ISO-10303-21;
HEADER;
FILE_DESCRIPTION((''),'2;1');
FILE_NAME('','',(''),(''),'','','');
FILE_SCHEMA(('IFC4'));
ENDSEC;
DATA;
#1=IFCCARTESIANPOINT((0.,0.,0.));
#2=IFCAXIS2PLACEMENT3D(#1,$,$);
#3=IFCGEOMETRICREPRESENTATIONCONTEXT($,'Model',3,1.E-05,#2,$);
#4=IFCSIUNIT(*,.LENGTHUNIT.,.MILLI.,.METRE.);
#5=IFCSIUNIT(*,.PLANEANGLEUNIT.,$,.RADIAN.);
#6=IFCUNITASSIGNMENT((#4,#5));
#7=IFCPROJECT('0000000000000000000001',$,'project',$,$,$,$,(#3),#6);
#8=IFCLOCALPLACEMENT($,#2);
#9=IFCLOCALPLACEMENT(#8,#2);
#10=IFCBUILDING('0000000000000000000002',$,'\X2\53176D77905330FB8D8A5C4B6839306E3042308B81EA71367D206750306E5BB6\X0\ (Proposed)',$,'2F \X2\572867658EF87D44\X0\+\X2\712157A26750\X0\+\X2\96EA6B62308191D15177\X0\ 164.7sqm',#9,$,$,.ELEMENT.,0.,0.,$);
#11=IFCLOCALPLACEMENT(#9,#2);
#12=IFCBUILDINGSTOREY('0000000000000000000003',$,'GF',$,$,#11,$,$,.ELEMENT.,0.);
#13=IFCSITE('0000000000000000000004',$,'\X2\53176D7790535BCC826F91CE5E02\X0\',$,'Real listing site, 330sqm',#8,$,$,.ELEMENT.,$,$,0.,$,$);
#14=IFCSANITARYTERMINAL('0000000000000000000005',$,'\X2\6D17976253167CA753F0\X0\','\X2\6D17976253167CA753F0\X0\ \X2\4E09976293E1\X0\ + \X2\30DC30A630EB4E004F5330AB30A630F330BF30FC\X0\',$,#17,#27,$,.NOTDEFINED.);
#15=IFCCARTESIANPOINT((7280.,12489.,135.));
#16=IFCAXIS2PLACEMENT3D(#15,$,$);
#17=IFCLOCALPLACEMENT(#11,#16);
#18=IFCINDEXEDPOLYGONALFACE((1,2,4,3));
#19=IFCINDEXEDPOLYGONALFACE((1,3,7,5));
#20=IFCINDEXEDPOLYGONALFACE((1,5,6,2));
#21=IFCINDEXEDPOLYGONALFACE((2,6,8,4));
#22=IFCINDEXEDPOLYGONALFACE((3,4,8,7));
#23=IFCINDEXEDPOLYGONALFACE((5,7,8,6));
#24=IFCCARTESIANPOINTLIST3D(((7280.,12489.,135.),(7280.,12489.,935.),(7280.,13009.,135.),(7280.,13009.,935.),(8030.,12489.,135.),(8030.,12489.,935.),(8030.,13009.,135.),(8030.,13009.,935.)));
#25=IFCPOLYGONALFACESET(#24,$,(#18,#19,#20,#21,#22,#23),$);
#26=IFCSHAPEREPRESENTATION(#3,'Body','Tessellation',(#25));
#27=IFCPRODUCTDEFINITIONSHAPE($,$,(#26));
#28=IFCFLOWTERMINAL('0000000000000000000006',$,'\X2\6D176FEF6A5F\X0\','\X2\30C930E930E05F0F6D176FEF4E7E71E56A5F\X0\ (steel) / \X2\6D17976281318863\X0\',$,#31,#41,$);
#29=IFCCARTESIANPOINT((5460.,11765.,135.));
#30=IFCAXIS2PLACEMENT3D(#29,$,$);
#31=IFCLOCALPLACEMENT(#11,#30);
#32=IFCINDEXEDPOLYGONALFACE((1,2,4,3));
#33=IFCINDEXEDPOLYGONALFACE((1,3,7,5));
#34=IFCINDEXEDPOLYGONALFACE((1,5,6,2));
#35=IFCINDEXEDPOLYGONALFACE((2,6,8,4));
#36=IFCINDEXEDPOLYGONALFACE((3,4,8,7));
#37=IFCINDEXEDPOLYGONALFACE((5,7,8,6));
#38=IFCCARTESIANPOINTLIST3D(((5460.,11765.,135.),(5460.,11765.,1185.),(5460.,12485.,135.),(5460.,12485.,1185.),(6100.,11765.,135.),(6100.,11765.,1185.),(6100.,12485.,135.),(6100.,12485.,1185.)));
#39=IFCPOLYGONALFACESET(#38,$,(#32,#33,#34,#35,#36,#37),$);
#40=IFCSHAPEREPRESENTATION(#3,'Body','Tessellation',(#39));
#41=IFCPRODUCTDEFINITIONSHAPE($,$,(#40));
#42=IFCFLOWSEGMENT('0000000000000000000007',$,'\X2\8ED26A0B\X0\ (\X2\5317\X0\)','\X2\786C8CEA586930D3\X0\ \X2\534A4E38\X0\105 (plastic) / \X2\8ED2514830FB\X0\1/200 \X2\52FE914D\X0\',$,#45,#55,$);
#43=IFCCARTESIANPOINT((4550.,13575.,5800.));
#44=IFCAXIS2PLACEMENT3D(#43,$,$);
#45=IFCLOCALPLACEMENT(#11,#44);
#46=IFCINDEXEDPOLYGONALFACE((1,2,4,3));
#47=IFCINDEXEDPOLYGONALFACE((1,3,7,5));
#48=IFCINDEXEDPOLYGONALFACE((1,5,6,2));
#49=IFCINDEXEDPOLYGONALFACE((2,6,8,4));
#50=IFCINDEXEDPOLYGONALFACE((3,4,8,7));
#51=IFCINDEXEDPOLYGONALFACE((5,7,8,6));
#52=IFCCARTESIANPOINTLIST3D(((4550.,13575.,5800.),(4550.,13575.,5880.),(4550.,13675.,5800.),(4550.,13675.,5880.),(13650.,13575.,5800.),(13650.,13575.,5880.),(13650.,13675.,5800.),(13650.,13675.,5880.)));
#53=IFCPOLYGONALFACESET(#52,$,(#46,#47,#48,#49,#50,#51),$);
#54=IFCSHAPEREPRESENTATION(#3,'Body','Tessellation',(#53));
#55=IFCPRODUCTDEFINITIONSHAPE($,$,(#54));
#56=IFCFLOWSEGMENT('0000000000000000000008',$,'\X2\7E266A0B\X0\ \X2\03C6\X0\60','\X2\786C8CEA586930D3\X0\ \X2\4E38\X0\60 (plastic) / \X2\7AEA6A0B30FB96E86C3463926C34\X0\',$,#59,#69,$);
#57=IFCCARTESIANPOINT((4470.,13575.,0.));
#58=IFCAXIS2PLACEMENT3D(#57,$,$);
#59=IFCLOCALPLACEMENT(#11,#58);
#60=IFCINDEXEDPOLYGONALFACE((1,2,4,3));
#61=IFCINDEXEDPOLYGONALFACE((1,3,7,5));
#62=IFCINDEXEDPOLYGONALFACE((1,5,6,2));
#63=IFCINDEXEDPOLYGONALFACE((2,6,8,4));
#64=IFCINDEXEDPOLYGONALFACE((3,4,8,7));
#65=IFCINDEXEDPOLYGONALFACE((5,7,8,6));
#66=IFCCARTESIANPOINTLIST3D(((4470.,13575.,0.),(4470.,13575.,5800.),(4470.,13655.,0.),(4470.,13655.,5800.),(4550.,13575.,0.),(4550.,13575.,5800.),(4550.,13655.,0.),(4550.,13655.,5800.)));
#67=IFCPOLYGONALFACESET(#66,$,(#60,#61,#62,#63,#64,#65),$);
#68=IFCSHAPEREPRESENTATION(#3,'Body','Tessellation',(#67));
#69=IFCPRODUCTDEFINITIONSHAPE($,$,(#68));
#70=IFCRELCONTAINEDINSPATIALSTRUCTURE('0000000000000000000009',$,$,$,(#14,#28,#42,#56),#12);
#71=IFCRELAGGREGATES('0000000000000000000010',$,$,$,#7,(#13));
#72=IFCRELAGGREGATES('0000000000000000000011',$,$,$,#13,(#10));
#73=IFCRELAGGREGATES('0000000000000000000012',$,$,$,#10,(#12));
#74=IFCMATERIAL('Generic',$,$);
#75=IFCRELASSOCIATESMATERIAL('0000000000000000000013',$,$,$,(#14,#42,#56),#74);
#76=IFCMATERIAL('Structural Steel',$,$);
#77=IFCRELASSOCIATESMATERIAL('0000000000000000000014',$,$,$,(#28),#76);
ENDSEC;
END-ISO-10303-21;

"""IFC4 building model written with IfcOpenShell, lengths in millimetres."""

from ifc_helpers import new_model, si_unit, frame, frame_2d, origin, place, context, project, spatial, rectangle, extrude, material, element, save


model = new_model("IFC4")

# Units and contexts
model_context = context("Model", 3, precision=1e-05, world=origin())
ifc_project = project(units=[si_unit("LENGTHUNIT", "METRE", prefix="MILLI"), si_unit("PLANEANGLEUNIT", "RADIAN")], contexts=[model_context])

# Site, building, storey
site_placement = place(None, origin())
site = spatial("IfcSite", under=ifc_project, at=site_placement, Name="北海道富良野市", ObjectType="Real listing site, 330sqm", CompositionType="ELEMENT", RefElevation=0.0)
building_placement = place(site_placement, origin())
building = spatial("IfcBuilding", under=site, at=building_placement, Name="北海道・越屋根のある自然素材の家 (Proposed)", ObjectType="2F 在来軸組+無垢材+雪止め金具 164.7sqm", CompositionType="ELEMENT", ElevationOfRefHeight=0.0, ElevationOfTerrain=0.0)
storey_placement = place(building_placement, origin())
storey = spatial("IfcBuildingStorey", under=building, at=storey_placement, Name="GF", CompositionType="ELEMENT", Elevation=0.0)

# Sanitary terminal
ifc_material_1 = material(Name="Generic")
sanitary_terminal_placement = place(storey_placement, frame((7280.0, 12489.0, 135.0)))
element("IfcSanitaryTerminal", 1, at=sanitary_terminal_placement, inside=storey, material=ifc_material_1, Name="洗面化粧台", Description="洗面化粧台 三面鏡 + ボウル一体カウンター", PredefinedType="NOTDEFINED", context=model_context, shape_type="SweptSolid", body=[
    extrude(rectangle(XDim=750.0, YDim=520.0, at=frame_2d((375.0, 260.0))), frame((7280.0, 12489.0, 135.0)), (0.0, 0.0, 1.0), 800.0),
])

# Flow terminal
ifc_material_2 = material(Name="Structural Steel")
flow_terminal_placement = place(storey_placement, frame((5460.0, 11765.0, 135.0)))
element("IfcFlowTerminal", 2, at=flow_terminal_placement, inside=storey, material=ifc_material_2, Name="洗濯機", Description="ドラム式洗濯乾燥機 (steel) / 洗面脱衣", context=model_context, shape_type="SweptSolid", body=[
    extrude(rectangle(XDim=640.0, YDim=720.0, at=frame_2d((320.0, 360.0))), frame((5460.0, 11765.0, 135.0)), (0.0, 0.0, 1.0), 1050.0),
])

# Flow segments
flow_segment_1_placement = place(storey_placement, frame((4550.0, 13575.0, 5800.0)))
element("IfcFlowSegment", 3, at=flow_segment_1_placement, inside=storey, material=ifc_material_1, Name="軒樋 (北)", Description="硬質塩ビ 半丸105 (plastic) / 軒先・1/200 勾配", context=model_context, shape_type="SweptSolid", body=[
    extrude(rectangle(XDim=9100.0, YDim=100.0, at=frame_2d((4550.0, 50.0))), frame((4550.0, 13575.0, 5800.0)), (0.0, 0.0, 1.0), 80.0),
])
flow_segment_2_placement = place(storey_placement, frame((4470.0, 13575.0, 0.0)))
element("IfcFlowSegment", 4, at=flow_segment_2_placement, inside=storey, material=ifc_material_1, Name="縦樋 φ60", Description="硬質塩ビ 丸60 (plastic) / 竪樋・雨水排水", context=model_context, shape_type="SweptSolid", body=[
    extrude(rectangle(XDim=80.0, YDim=80.0, at=frame_2d((40.0, 40.0))), frame((4470.0, 13575.0, 0.0)), (0.0, 0.0, 1.0), 5800.0),
])

save(model, "model.ifc")
